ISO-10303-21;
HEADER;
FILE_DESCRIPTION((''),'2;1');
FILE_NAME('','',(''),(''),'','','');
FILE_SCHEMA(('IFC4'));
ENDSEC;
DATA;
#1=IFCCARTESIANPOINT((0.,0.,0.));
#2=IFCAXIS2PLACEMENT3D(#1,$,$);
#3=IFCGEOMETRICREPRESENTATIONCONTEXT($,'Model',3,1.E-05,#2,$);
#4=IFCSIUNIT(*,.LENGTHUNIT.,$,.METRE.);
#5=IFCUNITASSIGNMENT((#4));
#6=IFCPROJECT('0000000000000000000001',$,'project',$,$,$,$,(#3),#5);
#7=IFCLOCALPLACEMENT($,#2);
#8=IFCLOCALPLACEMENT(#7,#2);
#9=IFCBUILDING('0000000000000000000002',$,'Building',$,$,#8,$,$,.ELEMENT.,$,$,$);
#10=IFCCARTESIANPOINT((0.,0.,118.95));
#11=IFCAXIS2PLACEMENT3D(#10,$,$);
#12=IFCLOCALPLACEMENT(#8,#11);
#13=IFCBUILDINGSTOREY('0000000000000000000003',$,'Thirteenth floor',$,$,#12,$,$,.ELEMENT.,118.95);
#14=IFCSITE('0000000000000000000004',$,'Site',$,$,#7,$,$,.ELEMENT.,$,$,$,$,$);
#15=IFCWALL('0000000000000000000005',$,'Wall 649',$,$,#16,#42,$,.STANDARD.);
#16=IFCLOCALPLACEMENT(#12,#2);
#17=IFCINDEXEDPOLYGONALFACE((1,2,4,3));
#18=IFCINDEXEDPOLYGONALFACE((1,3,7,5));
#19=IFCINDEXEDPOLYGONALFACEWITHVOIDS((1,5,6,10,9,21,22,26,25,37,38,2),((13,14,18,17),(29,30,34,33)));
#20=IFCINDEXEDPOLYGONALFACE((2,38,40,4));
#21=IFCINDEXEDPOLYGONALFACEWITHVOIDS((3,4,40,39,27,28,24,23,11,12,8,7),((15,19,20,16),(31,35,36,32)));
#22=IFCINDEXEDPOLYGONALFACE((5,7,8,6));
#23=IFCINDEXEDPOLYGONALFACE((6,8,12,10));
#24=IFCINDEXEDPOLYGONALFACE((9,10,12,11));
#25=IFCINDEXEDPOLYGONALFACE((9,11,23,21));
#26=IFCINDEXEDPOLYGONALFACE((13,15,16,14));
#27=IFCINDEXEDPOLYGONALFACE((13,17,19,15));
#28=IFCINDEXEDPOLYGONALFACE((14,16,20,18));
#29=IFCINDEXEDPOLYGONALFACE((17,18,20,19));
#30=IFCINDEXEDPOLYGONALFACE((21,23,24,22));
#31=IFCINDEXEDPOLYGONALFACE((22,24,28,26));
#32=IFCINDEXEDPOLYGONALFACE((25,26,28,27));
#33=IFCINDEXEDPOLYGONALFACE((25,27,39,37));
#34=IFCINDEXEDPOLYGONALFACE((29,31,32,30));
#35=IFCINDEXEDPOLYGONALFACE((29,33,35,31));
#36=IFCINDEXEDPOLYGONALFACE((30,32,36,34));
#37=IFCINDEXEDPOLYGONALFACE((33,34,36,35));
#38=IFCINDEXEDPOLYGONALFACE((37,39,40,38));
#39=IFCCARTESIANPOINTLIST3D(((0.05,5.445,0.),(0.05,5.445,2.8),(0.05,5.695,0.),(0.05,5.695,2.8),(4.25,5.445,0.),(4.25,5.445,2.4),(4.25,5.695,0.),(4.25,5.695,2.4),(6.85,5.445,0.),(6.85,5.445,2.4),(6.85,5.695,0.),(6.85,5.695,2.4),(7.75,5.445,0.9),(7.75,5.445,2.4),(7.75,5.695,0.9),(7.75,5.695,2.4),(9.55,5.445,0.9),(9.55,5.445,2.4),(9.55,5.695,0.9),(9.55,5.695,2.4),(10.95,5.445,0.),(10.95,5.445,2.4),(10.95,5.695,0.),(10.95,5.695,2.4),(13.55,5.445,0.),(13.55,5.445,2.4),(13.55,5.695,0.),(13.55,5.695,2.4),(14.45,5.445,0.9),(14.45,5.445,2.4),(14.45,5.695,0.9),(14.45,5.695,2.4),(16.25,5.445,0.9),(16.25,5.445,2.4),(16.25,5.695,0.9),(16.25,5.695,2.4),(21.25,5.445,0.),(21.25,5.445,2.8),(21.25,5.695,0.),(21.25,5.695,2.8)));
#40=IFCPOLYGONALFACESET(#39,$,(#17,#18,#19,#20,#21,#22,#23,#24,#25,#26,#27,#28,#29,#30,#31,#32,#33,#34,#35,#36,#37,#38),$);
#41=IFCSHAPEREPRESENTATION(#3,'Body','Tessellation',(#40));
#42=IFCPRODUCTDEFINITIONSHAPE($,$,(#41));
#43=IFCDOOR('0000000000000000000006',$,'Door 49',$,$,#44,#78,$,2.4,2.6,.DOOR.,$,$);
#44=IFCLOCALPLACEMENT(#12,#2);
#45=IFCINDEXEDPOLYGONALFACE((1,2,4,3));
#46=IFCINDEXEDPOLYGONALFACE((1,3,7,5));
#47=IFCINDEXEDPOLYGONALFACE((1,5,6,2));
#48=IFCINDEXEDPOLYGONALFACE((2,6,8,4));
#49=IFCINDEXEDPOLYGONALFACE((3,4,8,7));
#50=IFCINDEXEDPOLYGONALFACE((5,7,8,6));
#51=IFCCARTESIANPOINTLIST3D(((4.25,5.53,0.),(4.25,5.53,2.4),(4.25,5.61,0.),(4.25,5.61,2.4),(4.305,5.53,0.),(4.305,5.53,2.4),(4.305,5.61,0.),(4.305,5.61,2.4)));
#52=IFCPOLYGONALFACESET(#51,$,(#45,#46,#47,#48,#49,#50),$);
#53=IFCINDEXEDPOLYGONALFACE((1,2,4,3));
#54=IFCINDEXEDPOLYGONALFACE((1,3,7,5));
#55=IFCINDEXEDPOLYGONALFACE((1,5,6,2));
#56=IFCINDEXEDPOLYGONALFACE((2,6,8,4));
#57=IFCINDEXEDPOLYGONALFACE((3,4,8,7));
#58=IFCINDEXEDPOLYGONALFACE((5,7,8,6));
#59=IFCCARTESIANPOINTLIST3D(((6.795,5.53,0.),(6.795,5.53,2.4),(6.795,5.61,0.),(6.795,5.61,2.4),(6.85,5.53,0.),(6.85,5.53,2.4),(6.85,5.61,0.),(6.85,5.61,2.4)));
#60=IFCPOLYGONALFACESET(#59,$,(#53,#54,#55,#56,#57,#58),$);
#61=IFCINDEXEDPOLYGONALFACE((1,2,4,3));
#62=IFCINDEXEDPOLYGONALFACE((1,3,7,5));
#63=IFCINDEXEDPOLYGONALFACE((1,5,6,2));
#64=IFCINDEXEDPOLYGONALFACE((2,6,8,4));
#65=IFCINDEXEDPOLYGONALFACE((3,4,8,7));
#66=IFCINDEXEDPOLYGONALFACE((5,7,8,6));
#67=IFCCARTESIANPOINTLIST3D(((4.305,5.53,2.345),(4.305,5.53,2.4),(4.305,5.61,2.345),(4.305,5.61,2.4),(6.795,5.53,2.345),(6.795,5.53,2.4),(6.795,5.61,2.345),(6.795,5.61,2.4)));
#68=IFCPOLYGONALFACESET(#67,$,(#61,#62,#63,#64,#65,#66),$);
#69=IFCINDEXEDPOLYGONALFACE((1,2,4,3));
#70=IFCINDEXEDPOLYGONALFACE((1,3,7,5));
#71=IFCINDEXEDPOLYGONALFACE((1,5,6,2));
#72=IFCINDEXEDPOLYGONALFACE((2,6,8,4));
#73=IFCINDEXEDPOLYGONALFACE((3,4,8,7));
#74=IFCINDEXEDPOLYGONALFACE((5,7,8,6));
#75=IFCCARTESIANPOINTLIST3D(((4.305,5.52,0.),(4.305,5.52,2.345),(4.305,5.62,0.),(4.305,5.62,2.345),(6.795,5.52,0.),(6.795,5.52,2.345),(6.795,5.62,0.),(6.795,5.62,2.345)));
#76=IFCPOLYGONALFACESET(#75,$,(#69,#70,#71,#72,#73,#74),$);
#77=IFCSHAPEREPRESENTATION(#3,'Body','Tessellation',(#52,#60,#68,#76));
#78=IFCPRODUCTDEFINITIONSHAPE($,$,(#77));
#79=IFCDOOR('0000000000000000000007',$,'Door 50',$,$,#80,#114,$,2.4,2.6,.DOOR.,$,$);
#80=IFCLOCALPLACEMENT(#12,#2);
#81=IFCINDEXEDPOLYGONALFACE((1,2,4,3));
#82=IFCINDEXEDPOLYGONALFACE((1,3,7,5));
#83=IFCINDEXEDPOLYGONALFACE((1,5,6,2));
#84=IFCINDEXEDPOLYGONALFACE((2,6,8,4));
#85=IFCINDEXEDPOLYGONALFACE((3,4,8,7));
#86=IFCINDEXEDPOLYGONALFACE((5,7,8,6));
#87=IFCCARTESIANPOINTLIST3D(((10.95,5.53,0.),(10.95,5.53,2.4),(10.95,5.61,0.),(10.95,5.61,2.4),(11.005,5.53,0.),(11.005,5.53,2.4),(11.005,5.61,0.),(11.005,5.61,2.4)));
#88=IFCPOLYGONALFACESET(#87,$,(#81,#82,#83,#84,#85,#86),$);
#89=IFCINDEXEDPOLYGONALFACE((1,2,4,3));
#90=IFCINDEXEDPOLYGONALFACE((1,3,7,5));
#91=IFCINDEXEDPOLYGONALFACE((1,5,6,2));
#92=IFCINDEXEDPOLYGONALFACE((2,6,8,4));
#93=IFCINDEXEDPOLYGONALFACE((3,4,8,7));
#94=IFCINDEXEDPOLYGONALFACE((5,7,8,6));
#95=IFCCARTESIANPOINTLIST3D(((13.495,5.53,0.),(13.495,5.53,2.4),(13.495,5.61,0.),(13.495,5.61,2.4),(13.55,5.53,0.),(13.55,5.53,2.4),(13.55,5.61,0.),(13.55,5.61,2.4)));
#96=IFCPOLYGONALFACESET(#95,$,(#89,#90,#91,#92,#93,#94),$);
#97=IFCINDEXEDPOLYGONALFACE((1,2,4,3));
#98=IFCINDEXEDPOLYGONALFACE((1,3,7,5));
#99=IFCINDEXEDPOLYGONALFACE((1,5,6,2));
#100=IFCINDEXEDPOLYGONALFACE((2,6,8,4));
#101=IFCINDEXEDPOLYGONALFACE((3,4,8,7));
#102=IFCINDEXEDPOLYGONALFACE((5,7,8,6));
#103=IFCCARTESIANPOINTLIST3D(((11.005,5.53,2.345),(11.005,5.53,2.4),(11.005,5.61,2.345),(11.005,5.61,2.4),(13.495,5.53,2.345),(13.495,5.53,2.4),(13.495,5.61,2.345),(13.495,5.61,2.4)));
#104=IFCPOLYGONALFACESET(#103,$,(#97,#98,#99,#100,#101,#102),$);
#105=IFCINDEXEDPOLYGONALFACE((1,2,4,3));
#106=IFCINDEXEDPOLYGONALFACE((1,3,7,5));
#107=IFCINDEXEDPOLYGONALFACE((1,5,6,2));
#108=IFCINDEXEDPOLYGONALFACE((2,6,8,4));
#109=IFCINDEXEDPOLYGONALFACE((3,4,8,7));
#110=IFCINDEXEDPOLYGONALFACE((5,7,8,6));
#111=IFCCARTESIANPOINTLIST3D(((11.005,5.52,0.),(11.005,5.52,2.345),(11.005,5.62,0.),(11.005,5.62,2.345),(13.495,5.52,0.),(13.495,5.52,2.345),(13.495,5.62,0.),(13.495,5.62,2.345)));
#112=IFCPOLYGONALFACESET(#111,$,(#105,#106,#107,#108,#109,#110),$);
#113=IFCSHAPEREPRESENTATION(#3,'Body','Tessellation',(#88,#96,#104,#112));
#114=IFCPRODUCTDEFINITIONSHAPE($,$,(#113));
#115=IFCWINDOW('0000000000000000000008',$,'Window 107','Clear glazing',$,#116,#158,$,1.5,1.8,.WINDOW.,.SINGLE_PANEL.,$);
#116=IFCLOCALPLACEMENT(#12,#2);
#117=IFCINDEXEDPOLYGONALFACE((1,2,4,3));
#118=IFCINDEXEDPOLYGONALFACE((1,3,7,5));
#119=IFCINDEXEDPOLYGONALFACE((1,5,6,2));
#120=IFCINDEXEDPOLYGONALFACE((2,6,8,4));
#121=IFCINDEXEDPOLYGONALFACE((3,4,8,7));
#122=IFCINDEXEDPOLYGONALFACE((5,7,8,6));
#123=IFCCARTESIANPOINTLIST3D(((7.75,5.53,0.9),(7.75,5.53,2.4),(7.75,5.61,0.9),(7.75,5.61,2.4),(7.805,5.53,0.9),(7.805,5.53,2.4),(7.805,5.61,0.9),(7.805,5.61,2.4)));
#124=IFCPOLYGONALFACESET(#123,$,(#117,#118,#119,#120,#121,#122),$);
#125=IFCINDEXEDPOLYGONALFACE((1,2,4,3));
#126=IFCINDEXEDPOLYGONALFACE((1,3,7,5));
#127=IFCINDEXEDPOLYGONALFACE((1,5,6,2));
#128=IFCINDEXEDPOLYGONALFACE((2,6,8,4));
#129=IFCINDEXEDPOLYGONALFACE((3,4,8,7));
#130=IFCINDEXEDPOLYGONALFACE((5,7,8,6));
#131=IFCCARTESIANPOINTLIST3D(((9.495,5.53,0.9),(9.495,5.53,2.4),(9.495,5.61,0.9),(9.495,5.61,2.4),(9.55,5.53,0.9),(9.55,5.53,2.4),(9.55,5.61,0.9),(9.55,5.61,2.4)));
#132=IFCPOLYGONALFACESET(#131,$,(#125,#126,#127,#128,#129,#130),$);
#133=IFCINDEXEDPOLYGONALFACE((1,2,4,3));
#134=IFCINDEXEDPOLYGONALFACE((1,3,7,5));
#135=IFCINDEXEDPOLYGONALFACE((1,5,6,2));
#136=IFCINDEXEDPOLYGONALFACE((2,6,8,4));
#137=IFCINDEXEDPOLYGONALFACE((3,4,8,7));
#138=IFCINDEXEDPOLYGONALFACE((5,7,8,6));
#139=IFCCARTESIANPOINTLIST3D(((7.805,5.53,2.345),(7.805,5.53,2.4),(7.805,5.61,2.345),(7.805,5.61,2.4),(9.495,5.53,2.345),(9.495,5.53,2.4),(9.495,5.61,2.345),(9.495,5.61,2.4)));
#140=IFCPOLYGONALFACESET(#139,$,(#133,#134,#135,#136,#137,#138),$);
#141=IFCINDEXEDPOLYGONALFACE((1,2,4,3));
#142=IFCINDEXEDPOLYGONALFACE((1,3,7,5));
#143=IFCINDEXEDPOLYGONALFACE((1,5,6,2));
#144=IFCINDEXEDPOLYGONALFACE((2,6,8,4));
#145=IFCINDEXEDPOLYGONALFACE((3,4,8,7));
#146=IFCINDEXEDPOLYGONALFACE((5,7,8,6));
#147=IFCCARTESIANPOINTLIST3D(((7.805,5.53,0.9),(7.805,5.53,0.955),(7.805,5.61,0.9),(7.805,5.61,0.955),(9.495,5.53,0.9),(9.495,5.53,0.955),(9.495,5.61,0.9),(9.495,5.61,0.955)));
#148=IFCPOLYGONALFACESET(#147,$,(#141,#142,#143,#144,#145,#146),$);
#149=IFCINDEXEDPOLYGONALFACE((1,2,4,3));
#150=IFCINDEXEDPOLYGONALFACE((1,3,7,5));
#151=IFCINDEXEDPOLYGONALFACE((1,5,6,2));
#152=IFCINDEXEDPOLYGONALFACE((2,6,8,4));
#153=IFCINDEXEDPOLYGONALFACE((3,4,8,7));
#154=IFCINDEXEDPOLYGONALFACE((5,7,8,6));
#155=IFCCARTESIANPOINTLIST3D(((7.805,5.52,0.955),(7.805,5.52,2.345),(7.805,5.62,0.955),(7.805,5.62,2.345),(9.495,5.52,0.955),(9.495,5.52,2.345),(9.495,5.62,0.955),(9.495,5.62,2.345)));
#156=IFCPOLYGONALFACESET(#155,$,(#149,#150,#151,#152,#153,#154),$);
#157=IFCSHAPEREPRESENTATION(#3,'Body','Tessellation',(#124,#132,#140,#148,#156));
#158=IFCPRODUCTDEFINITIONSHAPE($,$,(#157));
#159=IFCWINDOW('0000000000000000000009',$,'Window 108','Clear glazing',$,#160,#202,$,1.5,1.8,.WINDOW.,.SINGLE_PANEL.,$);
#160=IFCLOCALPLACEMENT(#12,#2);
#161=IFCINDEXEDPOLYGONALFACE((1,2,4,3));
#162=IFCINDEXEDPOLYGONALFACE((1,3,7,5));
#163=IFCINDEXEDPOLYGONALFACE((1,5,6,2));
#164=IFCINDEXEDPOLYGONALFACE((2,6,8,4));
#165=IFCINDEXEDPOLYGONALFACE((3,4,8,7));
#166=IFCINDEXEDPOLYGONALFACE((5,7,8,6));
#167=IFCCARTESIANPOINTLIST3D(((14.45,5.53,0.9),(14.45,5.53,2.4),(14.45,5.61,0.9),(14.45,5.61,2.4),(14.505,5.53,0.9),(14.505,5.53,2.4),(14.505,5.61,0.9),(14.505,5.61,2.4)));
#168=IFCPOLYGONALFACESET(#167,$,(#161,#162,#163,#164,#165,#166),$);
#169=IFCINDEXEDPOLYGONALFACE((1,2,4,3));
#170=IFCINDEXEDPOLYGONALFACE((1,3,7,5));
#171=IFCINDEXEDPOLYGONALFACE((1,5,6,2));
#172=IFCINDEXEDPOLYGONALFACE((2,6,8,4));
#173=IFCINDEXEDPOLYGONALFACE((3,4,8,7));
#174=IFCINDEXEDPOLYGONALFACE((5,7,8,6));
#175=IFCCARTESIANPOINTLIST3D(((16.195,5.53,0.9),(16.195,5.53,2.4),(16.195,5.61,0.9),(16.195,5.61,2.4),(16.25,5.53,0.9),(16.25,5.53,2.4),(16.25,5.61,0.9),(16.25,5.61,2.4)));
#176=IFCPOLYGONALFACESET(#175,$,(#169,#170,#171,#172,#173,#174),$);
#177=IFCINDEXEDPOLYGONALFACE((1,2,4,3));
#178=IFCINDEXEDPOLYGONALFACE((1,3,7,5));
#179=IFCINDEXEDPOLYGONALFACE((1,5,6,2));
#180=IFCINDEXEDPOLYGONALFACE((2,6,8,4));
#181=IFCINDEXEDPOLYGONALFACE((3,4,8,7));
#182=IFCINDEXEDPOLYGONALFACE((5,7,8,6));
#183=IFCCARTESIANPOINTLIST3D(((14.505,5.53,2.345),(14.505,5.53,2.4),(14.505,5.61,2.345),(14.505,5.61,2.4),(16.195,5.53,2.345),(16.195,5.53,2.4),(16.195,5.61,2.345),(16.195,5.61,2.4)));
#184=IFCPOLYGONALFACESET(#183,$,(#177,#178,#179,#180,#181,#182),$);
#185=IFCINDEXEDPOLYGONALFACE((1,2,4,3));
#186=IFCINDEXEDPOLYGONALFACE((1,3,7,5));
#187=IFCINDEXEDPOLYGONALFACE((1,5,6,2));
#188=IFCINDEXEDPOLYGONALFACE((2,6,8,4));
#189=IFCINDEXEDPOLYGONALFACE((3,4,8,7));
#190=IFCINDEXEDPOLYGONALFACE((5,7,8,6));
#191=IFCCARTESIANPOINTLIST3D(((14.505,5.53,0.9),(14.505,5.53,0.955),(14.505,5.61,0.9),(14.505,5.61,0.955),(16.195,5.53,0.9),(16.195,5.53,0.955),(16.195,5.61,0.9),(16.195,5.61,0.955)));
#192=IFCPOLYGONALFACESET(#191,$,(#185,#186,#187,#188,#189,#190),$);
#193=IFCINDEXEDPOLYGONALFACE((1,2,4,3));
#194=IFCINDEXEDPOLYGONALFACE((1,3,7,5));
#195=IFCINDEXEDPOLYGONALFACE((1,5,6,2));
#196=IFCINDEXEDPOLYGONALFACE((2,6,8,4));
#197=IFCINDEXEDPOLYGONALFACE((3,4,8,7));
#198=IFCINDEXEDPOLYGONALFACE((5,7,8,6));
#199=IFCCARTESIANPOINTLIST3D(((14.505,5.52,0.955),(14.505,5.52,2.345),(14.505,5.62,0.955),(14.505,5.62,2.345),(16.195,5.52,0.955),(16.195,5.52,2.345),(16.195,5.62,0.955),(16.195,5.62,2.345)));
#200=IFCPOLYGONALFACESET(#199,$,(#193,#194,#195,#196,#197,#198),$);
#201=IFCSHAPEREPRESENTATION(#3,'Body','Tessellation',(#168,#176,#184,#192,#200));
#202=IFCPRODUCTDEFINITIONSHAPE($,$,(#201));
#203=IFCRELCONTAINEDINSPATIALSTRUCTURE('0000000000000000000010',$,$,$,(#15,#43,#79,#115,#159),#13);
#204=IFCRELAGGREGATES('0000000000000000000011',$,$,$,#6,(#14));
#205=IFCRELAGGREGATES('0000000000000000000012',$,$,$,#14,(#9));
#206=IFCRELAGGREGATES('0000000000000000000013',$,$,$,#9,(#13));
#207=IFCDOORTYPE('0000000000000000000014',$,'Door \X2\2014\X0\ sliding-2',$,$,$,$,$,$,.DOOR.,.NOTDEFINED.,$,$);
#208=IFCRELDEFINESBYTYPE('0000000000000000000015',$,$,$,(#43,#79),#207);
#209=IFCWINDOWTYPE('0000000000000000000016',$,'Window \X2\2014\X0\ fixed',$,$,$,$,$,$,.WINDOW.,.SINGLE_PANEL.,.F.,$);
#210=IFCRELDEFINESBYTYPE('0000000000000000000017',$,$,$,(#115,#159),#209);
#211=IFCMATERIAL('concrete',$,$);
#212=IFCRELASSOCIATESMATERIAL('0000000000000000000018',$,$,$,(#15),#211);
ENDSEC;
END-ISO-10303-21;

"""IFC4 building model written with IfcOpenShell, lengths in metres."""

from ifc_helpers import new_model, si_unit, frame, frame_2d, origin, place, context, project, spatial, rectangle, extrude, material, type_object, element, fill, save


model = new_model("IFC4")

# Units and contexts
model_context = context("Model", 3, precision=1e-05, world=origin())
ifc_project = project(units=[si_unit("LENGTHUNIT", "METRE")], contexts=[model_context])

# Site, building, storey
site_placement = place(None, origin())
site = spatial("IfcSite", under=ifc_project, at=site_placement, Name="Site", CompositionType="ELEMENT")
building_placement = place(site_placement, origin())
building = spatial("IfcBuilding", under=site, at=building_placement, Name="Building", CompositionType="ELEMENT")
storey_placement = place(building_placement, frame((0.0, 0.0, 118.95)))
storey = spatial("IfcBuildingStorey", under=building, at=storey_placement, Name="Thirteenth floor", CompositionType="ELEMENT", Elevation=118.95)

# Shared definitions
ifc_material = material(Name="concrete")

# Wall, openings, doors, windows
wall_1_placement = place(storey_placement, frame((0.05, 5.57, 0.0), z_axis=(0.0, 0.0, 1.0), x_axis=(1.0, 0.0, 0.0)))
wall_1 = element("IfcWall", 1, at=wall_1_placement, inside=storey, material=ifc_material, Name="Wall 649", PredefinedType="STANDARD", context=model_context, shape_type="SweptSolid", body=[
    extrude(rectangle(XDim=21.2, YDim=0.25, at=frame_2d((10.6, 0.0))), origin(), (0.0, 0.0, 1.0), 2.8),
])
opening_1_placement = place(storey_placement, frame((4.25, 5.57, 0.0), z_axis=(0.0, 0.0, 1.0), x_axis=(1.0, 0.0, 0.0)))
opening_1 = element("IfcOpeningElement", 2, at=opening_1_placement, cuts=wall_1, PredefinedType="OPENING", context=model_context, shape_type="SweptSolid", body=[
    extrude(rectangle(XDim=2.6, YDim=0.31, at=frame_2d((1.3, 0.0))), origin(), (0.0, 0.0, 1.0), 2.4),
])
opening_2_placement = place(storey_placement, frame((7.75, 5.57, 0.9), z_axis=(0.0, 0.0, 1.0), x_axis=(1.0, 0.0, 0.0)))
opening_2 = element("IfcOpeningElement", 3, at=opening_2_placement, cuts=wall_1, PredefinedType="OPENING", context=model_context, shape_type="SweptSolid", body=[
    extrude(rectangle(XDim=1.8, YDim=0.31, at=frame_2d((0.9, 0.0))), origin(), (0.0, 0.0, 1.0), 1.5),
])
opening_3_placement = place(storey_placement, frame((10.95, 5.57, 0.0), z_axis=(0.0, 0.0, 1.0), x_axis=(1.0, 0.0, 0.0)))
opening_3 = element("IfcOpeningElement", 4, at=opening_3_placement, cuts=wall_1, PredefinedType="OPENING", context=model_context, shape_type="SweptSolid", body=[
    extrude(rectangle(XDim=2.6, YDim=0.31, at=frame_2d((1.3, 0.0))), origin(), (0.0, 0.0, 1.0), 2.4),
])
opening_4_placement = place(storey_placement, frame((14.45, 5.57, 0.9), z_axis=(0.0, 0.0, 1.0), x_axis=(1.0, 0.0, 0.0)))
opening_4 = element("IfcOpeningElement", 5, at=opening_4_placement, cuts=wall_1, PredefinedType="OPENING", context=model_context, shape_type="SweptSolid", body=[
    extrude(rectangle(XDim=1.8, YDim=0.31, at=frame_2d((0.9, 0.0))), origin(), (0.0, 0.0, 1.0), 1.5),
])
door_type = type_object("IfcDoorType", Name="Door — sliding-2", PredefinedType="DOOR")
door_1_placement = place(storey_placement, frame((4.25, 5.57, 0.0), z_axis=(0.0, 0.0, 1.0), x_axis=(1.0, 0.0, 0.0)))
door_1 = element("IfcDoor", 6, at=door_1_placement, inside=storey, type_object=door_type, Name="Door 49", OverallHeight=2.4, OverallWidth=2.6, PredefinedType="DOOR", context=model_context, shape_type="SweptSolid", body=[
    extrude(rectangle(XDim=0.055, YDim=0.08, at=frame_2d((0.0275, 0.0))), origin(), (0.0, 0.0, 1.0), 2.4),
    extrude(rectangle(XDim=0.055, YDim=0.08, at=frame_2d((2.5725, 0.0))), origin(), (0.0, 0.0, 1.0), 2.4),
    extrude(rectangle(XDim=2.49, YDim=0.08, at=frame_2d((1.3, 0.0))), frame((0.0, 0.0, 2.345)), (0.0, 0.0, 1.0), 0.055),
    extrude(rectangle(XDim=2.49, YDim=0.1, at=frame_2d((1.3, 0.0))), origin(), (0.0, 0.0, 1.0), 2.345),
])
fill(opening_1, door_1)
door_2_placement = place(storey_placement, frame((10.95, 5.57, 0.0), z_axis=(0.0, 0.0, 1.0), x_axis=(1.0, 0.0, 0.0)))
door_2 = element("IfcDoor", 7, at=door_2_placement, inside=storey, type_object=door_type, Name="Door 50", OverallHeight=2.4, OverallWidth=2.6, PredefinedType="DOOR", context=model_context, shape_type="SweptSolid", body=[
    extrude(rectangle(XDim=0.055, YDim=0.08, at=frame_2d((0.0275, 0.0))), origin(), (0.0, 0.0, 1.0), 2.4),
    extrude(rectangle(XDim=0.055, YDim=0.08, at=frame_2d((2.5725, 0.0))), origin(), (0.0, 0.0, 1.0), 2.4),
    extrude(rectangle(XDim=2.49, YDim=0.08, at=frame_2d((1.3, 0.0))), frame((0.0, 0.0, 2.345)), (0.0, 0.0, 1.0), 0.055),
    extrude(rectangle(XDim=2.49, YDim=0.1, at=frame_2d((1.3, 0.0))), origin(), (0.0, 0.0, 1.0), 2.345),
])
fill(opening_3, door_2)
window_type = type_object("IfcWindowType", Name="Window — fixed", ParameterTakesPrecedence=False, PartitioningType="SINGLE_PANEL", PredefinedType="WINDOW")
window_1_placement = place(storey_placement, frame((7.75, 5.57, 0.9), z_axis=(0.0, 0.0, 1.0), x_axis=(1.0, 0.0, 0.0)))
window_1 = element("IfcWindow", 8, at=window_1_placement, inside=storey, type_object=window_type, Name="Window 107", Description="Clear glazing", OverallHeight=1.5, OverallWidth=1.8, PartitioningType="SINGLE_PANEL", PredefinedType="WINDOW", context=model_context, shape_type="SweptSolid", body=[
    extrude(rectangle(XDim=0.055, YDim=0.08, at=frame_2d((0.0275, 0.0))), origin(), (0.0, 0.0, 1.0), 1.5),
    extrude(rectangle(XDim=0.055, YDim=0.08, at=frame_2d((1.7725, 0.0))), origin(), (0.0, 0.0, 1.0), 1.5),
    extrude(rectangle(XDim=1.69, YDim=0.08, at=frame_2d((0.9, 0.0))), frame((0.0, 0.0, 1.445)), (0.0, 0.0, 1.0), 0.055),
    extrude(rectangle(XDim=1.69, YDim=0.08, at=frame_2d((0.9, 0.0))), origin(), (0.0, 0.0, 1.0), 0.055),
    extrude(rectangle(XDim=1.69, YDim=0.1, at=frame_2d((0.9, 0.0))), frame((0.0, 0.0, 0.055)), (0.0, 0.0, 1.0), 1.39),
])
fill(opening_2, window_1)
window_2_placement = place(storey_placement, frame((14.45, 5.57, 0.9), z_axis=(0.0, 0.0, 1.0), x_axis=(1.0, 0.0, 0.0)))
window_2 = element("IfcWindow", 9, at=window_2_placement, inside=storey, type_object=window_type, Name="Window 108", Description="Clear glazing", OverallHeight=1.5, OverallWidth=1.8, PartitioningType="SINGLE_PANEL", PredefinedType="WINDOW", context=model_context, shape_type="SweptSolid", body=[
    extrude(rectangle(XDim=0.055, YDim=0.08, at=frame_2d((0.0275, 0.0))), origin(), (0.0, 0.0, 1.0), 1.5),
    extrude(rectangle(XDim=0.055, YDim=0.08, at=frame_2d((1.7725, 0.0))), origin(), (0.0, 0.0, 1.0), 1.5),
    extrude(rectangle(XDim=1.69, YDim=0.08, at=frame_2d((0.9, 0.0))), frame((0.0, 0.0, 1.445)), (0.0, 0.0, 1.0), 0.055),
    extrude(rectangle(XDim=1.69, YDim=0.08, at=frame_2d((0.9, 0.0))), origin(), (0.0, 0.0, 1.0), 0.055),
    extrude(rectangle(XDim=1.69, YDim=0.1, at=frame_2d((0.9, 0.0))), frame((0.0, 0.0, 0.055)), (0.0, 0.0, 1.0), 1.39),
])
fill(opening_4, window_2)

save(model, "model.ifc")
